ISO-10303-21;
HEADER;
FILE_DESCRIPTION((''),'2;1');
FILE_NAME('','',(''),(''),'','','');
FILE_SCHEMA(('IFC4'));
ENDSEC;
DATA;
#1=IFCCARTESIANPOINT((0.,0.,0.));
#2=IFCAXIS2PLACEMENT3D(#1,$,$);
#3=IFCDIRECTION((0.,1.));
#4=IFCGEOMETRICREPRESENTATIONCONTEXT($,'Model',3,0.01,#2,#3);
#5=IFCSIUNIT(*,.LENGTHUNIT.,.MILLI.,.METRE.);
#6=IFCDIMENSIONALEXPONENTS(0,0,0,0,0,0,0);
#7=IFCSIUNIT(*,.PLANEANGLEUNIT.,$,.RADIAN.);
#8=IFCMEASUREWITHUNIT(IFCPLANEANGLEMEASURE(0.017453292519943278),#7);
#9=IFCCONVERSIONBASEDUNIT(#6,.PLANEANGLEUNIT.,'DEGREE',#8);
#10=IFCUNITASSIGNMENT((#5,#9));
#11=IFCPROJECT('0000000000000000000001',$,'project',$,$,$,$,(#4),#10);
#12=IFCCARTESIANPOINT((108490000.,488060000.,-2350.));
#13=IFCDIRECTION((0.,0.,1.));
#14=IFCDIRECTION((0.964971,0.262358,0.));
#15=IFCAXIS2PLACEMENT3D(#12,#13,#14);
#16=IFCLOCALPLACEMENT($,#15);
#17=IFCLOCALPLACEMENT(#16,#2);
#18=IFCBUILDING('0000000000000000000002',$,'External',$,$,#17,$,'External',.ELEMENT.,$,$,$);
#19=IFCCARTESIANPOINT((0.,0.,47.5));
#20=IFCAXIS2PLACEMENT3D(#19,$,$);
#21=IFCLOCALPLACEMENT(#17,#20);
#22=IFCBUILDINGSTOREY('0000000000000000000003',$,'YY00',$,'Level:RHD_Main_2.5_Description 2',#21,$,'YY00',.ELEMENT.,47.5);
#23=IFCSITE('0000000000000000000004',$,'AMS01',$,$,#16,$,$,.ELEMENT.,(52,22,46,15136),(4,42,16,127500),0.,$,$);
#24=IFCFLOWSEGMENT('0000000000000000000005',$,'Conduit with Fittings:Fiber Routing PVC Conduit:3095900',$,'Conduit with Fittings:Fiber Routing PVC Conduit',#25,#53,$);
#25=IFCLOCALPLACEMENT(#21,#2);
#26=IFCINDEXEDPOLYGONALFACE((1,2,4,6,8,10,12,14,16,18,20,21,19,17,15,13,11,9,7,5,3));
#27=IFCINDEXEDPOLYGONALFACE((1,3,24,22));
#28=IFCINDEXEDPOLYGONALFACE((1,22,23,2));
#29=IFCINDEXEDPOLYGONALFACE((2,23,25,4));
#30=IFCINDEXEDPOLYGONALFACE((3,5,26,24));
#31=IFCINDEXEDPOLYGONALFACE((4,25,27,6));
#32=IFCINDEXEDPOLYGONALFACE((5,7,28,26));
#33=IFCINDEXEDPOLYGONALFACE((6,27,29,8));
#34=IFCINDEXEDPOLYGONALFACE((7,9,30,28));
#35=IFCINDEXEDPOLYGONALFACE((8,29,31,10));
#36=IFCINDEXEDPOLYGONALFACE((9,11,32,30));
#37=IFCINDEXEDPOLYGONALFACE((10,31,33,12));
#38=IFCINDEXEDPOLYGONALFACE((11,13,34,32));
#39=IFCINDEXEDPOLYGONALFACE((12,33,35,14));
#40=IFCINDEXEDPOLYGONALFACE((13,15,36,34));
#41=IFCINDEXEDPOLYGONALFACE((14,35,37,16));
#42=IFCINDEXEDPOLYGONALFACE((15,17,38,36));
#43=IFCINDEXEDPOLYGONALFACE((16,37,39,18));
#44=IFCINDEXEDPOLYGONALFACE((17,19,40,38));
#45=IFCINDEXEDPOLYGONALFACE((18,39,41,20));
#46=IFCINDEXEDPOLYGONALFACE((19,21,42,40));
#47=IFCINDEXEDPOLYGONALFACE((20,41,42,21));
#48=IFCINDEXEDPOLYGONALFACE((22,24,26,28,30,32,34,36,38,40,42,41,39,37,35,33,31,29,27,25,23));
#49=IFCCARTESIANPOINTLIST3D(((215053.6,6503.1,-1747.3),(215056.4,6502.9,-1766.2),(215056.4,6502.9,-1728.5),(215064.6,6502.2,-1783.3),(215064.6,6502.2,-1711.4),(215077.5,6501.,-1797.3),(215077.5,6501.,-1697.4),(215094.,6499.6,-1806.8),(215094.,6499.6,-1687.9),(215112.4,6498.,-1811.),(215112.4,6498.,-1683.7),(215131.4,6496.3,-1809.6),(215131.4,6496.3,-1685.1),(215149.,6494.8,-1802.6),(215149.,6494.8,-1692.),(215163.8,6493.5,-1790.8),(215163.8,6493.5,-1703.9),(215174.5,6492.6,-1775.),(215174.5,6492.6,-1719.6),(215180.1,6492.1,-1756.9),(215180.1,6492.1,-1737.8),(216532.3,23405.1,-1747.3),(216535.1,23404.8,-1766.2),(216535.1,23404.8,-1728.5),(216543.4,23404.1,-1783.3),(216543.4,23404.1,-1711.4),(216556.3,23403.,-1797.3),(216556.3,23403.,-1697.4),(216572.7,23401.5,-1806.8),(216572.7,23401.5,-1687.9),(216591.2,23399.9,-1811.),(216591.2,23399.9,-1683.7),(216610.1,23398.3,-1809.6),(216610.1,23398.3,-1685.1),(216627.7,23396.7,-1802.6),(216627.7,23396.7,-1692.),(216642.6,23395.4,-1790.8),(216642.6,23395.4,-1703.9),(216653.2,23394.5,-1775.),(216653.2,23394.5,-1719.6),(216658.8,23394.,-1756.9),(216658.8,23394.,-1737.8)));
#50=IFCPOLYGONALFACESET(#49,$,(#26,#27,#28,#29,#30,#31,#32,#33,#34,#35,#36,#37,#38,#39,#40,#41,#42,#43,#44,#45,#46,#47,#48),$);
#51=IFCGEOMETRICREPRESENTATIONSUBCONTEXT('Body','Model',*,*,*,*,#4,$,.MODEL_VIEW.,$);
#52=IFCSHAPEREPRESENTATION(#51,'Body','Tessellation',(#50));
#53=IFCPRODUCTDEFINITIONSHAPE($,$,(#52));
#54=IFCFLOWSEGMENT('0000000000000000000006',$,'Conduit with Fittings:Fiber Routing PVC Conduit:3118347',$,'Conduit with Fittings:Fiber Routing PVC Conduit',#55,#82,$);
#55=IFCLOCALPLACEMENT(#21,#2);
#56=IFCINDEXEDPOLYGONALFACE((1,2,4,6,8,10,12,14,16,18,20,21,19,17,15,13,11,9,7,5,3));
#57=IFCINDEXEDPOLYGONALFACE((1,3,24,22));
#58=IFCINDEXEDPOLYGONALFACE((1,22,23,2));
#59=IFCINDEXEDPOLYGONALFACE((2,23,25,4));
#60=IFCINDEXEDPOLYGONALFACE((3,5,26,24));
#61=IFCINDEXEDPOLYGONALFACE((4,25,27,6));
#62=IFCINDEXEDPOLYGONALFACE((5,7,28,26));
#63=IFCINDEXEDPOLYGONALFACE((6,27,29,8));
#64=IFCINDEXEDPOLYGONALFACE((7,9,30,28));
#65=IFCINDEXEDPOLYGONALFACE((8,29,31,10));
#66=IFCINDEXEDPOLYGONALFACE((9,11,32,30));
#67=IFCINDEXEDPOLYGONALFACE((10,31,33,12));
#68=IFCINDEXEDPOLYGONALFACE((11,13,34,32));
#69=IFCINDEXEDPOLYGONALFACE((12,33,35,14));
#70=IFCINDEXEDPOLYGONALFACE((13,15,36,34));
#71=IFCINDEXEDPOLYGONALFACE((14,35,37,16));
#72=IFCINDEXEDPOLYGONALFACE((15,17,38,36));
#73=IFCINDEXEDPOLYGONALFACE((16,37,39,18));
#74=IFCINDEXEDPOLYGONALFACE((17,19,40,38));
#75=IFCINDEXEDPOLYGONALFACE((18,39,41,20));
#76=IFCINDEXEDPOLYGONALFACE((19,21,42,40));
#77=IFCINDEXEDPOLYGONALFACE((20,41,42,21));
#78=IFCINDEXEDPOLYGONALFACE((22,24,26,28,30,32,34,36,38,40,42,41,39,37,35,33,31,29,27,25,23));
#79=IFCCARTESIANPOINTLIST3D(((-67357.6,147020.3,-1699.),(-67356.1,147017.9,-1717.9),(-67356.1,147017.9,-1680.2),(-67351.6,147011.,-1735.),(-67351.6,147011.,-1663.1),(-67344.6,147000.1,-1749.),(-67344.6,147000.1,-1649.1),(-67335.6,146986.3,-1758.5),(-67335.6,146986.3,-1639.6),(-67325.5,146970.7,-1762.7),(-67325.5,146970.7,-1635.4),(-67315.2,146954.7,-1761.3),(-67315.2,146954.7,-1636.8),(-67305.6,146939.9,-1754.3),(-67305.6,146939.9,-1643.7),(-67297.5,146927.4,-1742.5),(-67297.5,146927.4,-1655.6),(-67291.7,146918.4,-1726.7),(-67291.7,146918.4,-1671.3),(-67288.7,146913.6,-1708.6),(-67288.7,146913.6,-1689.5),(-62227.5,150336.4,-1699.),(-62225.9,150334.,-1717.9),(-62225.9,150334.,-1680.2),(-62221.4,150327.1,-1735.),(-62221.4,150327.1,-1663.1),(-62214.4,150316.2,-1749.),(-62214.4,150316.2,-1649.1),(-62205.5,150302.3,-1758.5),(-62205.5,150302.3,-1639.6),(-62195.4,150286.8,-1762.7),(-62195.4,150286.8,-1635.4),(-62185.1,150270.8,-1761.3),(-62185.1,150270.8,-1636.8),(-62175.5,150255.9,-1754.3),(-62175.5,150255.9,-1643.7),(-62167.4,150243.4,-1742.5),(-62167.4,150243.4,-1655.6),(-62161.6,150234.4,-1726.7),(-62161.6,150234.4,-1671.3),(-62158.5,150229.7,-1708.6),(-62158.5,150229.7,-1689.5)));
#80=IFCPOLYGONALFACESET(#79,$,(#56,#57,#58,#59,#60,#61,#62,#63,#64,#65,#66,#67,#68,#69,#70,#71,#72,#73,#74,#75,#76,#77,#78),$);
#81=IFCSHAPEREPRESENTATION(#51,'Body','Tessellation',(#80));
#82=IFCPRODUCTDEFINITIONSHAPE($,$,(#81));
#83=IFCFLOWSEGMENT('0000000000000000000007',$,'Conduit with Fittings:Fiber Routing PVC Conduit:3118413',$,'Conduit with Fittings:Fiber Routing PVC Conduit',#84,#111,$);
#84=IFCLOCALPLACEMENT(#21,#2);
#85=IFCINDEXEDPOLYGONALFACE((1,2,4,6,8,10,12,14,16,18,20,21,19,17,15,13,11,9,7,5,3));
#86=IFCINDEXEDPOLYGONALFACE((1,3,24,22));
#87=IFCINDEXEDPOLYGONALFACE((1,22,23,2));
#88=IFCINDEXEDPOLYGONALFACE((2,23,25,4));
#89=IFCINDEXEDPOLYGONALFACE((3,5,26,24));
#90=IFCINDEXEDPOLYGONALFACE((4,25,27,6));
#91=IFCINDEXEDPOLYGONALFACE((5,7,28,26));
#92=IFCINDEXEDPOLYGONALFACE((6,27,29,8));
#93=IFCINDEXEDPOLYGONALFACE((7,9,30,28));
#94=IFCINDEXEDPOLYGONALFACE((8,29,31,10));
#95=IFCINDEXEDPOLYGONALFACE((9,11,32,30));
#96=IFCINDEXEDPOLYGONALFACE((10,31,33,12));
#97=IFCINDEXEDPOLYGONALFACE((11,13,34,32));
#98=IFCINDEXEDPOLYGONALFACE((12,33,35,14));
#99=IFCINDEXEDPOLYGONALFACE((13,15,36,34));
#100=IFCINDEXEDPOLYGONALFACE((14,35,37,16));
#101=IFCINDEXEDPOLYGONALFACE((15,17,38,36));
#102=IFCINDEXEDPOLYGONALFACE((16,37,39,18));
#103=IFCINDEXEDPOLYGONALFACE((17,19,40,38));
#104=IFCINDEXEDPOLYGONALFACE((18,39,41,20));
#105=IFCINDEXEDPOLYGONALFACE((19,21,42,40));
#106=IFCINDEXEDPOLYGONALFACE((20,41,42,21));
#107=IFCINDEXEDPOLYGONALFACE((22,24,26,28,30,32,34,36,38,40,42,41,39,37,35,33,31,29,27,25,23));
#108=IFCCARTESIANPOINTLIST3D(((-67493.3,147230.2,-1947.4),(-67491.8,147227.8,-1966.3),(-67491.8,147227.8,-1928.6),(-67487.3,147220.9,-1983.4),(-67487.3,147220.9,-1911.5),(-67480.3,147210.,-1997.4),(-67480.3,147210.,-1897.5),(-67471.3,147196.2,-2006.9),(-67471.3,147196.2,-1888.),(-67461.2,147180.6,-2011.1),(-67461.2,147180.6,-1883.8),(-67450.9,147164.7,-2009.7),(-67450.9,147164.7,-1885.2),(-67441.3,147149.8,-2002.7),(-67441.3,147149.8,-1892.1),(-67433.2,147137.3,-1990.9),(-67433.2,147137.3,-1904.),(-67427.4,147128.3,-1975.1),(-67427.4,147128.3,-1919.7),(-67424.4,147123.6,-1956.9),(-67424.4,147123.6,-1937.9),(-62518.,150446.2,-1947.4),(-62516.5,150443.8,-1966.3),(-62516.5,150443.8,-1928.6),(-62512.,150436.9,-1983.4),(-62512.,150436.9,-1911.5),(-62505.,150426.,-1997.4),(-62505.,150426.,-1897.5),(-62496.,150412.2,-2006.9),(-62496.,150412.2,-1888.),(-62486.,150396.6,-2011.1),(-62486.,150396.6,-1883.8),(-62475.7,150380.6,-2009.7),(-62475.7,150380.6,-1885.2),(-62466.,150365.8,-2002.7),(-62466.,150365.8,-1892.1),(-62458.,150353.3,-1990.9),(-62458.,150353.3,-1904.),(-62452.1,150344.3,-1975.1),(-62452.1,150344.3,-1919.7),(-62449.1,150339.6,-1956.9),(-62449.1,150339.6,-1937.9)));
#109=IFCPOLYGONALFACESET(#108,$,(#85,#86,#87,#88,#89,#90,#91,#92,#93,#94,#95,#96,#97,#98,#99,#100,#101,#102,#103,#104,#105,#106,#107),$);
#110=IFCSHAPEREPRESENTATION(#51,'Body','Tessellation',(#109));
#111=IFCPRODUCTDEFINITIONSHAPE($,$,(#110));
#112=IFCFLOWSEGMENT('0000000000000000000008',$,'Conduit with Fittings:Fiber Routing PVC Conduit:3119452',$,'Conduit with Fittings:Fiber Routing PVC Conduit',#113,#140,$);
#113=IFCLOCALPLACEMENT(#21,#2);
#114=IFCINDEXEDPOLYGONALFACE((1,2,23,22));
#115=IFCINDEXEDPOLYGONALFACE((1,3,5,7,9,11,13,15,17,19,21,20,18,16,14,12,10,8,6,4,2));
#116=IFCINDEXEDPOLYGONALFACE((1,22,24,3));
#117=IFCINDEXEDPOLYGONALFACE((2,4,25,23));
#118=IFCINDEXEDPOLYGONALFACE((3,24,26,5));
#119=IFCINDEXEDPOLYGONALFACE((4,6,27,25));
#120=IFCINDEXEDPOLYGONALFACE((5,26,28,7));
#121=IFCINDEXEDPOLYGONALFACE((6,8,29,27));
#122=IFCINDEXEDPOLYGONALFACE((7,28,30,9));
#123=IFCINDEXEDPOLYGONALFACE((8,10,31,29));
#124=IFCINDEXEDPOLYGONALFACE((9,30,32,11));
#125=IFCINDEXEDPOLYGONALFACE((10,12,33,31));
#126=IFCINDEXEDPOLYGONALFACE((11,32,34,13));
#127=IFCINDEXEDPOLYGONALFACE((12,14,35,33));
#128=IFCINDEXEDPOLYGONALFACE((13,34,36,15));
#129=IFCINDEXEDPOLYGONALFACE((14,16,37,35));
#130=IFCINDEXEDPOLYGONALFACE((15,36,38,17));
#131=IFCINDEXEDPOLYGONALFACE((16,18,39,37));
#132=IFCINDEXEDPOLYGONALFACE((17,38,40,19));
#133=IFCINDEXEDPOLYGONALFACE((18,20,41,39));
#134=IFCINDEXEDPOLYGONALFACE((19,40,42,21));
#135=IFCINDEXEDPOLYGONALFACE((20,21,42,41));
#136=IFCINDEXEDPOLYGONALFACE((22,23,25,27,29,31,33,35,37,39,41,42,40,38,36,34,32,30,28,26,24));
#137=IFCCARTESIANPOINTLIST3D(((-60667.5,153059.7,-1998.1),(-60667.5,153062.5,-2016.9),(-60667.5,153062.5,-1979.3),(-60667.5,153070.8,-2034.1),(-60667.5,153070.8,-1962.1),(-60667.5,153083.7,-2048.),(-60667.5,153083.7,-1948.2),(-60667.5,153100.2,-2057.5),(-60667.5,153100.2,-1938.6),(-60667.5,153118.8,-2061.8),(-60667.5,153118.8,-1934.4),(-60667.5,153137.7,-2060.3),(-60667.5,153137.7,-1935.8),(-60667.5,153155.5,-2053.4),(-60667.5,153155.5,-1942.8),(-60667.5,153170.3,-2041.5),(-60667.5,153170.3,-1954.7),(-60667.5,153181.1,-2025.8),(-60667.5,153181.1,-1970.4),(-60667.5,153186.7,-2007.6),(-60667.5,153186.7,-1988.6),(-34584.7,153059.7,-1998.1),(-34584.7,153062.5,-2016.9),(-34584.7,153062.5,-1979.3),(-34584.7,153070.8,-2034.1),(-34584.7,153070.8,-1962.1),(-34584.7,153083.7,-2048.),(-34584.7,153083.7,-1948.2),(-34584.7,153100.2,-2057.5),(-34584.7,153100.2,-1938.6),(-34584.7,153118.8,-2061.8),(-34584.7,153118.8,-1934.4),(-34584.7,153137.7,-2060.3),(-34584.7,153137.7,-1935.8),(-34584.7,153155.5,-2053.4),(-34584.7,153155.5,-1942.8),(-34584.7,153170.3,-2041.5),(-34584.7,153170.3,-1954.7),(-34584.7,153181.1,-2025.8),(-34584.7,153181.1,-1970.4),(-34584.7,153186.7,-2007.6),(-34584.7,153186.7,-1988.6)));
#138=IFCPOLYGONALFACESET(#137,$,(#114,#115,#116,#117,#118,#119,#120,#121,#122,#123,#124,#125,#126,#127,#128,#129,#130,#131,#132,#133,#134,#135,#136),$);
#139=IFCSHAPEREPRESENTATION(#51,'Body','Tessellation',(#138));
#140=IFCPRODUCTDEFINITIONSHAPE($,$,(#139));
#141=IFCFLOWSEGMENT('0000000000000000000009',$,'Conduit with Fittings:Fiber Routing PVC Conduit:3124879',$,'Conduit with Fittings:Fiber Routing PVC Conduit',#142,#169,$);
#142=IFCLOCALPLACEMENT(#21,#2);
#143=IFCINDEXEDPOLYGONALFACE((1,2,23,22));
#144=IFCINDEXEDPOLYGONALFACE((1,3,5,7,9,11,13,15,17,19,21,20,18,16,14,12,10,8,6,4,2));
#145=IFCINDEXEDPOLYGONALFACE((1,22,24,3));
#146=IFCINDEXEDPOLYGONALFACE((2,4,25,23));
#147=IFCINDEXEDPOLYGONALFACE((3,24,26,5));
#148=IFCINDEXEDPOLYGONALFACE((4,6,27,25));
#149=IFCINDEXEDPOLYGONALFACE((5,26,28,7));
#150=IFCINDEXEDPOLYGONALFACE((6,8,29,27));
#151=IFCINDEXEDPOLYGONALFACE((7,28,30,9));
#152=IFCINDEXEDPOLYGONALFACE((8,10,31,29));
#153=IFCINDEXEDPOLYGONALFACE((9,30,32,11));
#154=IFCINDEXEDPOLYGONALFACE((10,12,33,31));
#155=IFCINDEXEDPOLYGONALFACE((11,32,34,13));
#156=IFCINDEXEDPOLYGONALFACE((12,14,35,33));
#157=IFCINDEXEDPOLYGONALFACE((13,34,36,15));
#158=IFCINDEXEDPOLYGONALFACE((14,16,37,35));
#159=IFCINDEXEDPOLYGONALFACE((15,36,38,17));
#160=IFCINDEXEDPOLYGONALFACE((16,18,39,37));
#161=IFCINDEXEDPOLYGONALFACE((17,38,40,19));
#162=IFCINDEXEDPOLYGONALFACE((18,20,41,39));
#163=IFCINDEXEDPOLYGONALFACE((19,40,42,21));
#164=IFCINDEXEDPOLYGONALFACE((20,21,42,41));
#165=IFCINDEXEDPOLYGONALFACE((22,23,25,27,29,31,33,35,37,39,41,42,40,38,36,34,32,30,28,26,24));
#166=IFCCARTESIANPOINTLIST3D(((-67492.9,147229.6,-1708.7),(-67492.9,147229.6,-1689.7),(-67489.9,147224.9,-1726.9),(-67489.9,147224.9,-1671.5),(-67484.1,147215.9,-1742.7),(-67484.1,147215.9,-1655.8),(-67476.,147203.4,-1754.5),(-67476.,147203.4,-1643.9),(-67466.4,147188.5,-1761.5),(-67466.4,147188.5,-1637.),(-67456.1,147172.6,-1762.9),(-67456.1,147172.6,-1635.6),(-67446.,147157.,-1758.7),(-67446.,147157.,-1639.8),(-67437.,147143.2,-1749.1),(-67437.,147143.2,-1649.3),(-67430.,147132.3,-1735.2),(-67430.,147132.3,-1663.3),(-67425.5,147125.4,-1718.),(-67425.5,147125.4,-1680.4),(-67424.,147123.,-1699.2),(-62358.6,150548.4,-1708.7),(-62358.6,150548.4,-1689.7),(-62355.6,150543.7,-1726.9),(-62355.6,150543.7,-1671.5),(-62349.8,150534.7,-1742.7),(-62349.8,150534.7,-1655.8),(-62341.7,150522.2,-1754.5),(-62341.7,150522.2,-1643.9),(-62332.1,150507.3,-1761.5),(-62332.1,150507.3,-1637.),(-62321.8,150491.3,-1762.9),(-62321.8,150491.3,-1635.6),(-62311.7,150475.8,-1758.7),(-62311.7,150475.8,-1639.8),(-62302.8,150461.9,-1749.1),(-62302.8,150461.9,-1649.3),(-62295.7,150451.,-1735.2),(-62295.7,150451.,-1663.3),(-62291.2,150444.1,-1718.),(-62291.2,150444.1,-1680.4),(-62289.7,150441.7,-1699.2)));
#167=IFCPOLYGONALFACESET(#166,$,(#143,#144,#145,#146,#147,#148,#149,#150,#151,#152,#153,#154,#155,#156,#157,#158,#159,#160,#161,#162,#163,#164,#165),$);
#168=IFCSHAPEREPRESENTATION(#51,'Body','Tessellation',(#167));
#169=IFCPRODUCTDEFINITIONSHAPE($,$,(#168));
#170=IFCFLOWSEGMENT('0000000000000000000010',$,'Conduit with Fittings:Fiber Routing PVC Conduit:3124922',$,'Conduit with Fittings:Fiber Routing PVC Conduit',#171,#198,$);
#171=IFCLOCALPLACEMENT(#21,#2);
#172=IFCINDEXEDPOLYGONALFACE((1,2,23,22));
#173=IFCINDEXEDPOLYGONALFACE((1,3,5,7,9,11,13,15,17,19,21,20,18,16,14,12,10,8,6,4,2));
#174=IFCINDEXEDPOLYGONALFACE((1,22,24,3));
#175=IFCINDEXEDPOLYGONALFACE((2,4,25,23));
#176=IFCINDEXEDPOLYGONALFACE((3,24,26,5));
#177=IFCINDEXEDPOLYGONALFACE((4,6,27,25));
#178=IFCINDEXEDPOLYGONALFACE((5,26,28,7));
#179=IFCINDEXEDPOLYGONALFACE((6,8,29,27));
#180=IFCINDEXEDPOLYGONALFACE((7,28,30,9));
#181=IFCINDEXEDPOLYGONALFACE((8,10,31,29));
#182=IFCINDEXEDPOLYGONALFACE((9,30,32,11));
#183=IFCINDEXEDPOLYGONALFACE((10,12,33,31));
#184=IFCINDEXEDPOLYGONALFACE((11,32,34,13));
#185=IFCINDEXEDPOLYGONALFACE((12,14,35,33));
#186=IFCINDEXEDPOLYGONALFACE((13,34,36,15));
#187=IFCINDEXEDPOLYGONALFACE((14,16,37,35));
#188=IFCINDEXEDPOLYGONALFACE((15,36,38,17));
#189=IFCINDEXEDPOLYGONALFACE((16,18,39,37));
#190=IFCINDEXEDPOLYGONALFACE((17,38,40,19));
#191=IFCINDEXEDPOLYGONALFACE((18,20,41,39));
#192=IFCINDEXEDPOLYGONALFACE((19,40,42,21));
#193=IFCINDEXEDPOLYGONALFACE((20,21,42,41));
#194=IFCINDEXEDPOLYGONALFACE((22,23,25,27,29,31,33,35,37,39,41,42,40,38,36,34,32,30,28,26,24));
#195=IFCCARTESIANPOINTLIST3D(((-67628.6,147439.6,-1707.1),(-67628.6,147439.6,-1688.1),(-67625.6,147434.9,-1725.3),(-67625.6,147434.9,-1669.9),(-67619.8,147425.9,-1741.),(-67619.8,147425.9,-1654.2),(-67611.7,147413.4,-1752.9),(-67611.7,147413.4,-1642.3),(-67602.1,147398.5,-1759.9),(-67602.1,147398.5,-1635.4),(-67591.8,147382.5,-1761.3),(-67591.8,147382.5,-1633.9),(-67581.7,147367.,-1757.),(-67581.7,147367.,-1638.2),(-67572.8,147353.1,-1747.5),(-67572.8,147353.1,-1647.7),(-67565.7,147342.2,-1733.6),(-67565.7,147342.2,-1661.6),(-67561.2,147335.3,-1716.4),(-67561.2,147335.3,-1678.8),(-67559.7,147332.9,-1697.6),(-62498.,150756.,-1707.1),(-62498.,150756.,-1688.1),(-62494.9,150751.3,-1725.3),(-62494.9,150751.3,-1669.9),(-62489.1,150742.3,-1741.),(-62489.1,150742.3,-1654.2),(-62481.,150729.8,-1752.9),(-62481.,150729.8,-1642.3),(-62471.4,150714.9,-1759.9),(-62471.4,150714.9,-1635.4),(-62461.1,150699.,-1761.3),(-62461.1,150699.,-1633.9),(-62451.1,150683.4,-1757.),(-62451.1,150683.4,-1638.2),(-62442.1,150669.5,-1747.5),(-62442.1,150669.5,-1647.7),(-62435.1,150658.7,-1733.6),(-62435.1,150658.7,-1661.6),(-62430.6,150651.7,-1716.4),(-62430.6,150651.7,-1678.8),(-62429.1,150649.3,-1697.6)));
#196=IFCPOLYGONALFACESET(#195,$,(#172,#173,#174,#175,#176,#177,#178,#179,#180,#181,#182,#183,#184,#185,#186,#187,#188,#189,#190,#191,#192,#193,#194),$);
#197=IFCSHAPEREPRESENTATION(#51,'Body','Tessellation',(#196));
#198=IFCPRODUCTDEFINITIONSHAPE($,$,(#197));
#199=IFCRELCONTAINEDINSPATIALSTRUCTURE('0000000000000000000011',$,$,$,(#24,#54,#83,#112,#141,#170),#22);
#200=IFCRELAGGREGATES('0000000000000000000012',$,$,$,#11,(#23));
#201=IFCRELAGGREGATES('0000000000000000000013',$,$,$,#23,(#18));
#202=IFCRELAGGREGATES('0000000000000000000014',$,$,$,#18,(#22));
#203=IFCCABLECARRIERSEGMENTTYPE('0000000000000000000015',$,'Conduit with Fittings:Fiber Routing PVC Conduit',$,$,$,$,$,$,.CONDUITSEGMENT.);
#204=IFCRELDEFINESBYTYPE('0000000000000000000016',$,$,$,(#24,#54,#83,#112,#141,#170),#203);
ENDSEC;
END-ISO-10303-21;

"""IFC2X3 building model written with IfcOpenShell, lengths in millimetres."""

from ifc_helpers import new_model, entity, si_unit, converted_unit, direction, frame, frame_2d, origin, origin_2d_with_axis, place, context, subcontext, project, spatial, circle, extrude, type_object, element, save


model = new_model("IFC2X3")

# Units and contexts
model_context = context("Model", 3, precision=0.01, world=origin(), true_north=direction((0.0, 1.0)))
body_context = subcontext(model_context, "Body", "Model", "MODEL_VIEW")
ifc_project = project(units=[si_unit("LENGTHUNIT", "METRE", prefix="MILLI"), converted_unit("PLANEANGLEUNIT", "DEGREE", entity("IfcPlaneAngleMeasure", 0.017453292519943278), si_unit("PLANEANGLEUNIT", "RADIAN"), dimensions=[0, 0, 0, 0, 0, 0, 0])], contexts=[model_context])

# Site, building, storey
site_placement = place(None, frame((108490000.0, 488060000.0, -2350.0), z_axis=(0.0, 0.0, 1.0), x_axis=(0.964971, 0.262358, 0.0)))
site = spatial("IfcSite", under=ifc_project, at=site_placement, Name="AMS01", CompositionType="ELEMENT", RefLatitude=(52, 22, 46, 15136), RefLongitude=(4, 42, 16, 127500), RefElevation=0.0)
building_placement = place(site_placement, origin())
building = spatial("IfcBuilding", under=site, at=building_placement, Name="External", LongName="External", CompositionType="ELEMENT")
storey_placement = place(building_placement, frame((0.0, 0.0, 47.5)))
storey = spatial("IfcBuildingStorey", under=building, at=storey_placement, Name="YY00", ObjectType="Level:RHD_Main_2.5_Description 2", LongName="YY00", CompositionType="ELEMENT", Elevation=47.5)

# Flow segments
cable_carrier_segment_type = type_object("IfcCableCarrierSegmentType", Name="Conduit with Fittings:Fiber Routing PVC Conduit", PredefinedType="CONDUITSEGMENT")
flow_segment_1_placement = place(storey_placement, origin())
element("IfcFlowSegment", 1, at=flow_segment_1_placement, inside=storey, type_object=cable_carrier_segment_type, Name="Conduit with Fittings:Fiber Routing PVC Conduit:3095900", ObjectType="Conduit with Fittings:Fiber Routing PVC Conduit", context=body_context, shape_type="SweptSolid", body=[
    extrude(circle(Radius=63.9, at=frame_2d((0.0, 0.0), x_axis=(1.0, 0.0))), frame((215117.2, 6497.6, -1747.3), z_axis=(0.087156, 0.996195, 0.0), x_axis=(-0.996195, 0.087156, 0.0)), (0.0, 0.0, 1.0), 16966.5),
])
flow_segment_2_placement = place(storey_placement, origin())
element("IfcFlowSegment", 2, at=flow_segment_2_placement, inside=storey, type_object=cable_carrier_segment_type, Name="Conduit with Fittings:Fiber Routing PVC Conduit:3118347", ObjectType="Conduit with Fittings:Fiber Routing PVC Conduit", context=body_context, shape_type="SweptSolid", body=[
    extrude(circle(Radius=63.9, at=frame_2d((0.0, 0.0), x_axis=(1.0, 0.0))), frame((-67323.0, 146966.7, -1699.0), z_axis=(0.839826, 0.542856, 0.0), x_axis=(-0.542856, 0.839826, 0.0)), (0.0, 0.0, 1.0), 6108.6),
])
flow_segment_3_placement = place(storey_placement, origin())
element("IfcFlowSegment", 3, at=flow_segment_3_placement, inside=storey, type_object=cable_carrier_segment_type, Name="Conduit with Fittings:Fiber Routing PVC Conduit:3118413", ObjectType="Conduit with Fittings:Fiber Routing PVC Conduit", context=body_context, shape_type="SweptSolid", body=[
    extrude(circle(Radius=63.9, at=frame_2d((0.0, 0.0), x_axis=(1.0, 0.0))), frame((-67458.6, 147176.6, -1947.4), z_axis=(0.839826, 0.542856, 0.0), x_axis=(-0.542856, 0.839826, 0.0)), (0.0, 0.0, 1.0), 5924.2),
])
flow_segment_4_placement = place(storey_placement, origin())
element("IfcFlowSegment", 4, at=flow_segment_4_placement, inside=storey, type_object=cable_carrier_segment_type, Name="Conduit with Fittings:Fiber Routing PVC Conduit:3119452", ObjectType="Conduit with Fittings:Fiber Routing PVC Conduit", context=body_context, shape_type="SweptSolid", body=[
    extrude(circle(Radius=63.9, at=origin_2d_with_axis()), frame((-60667.5, 153123.5, -1998.1), z_axis=(1.0, 0.0, 0.0), x_axis=(0.0, -1.0, 0.0)), (0.0, 0.0, 1.0), 26082.9),
])
flow_segment_5_placement = place(storey_placement, origin())
element("IfcFlowSegment", 5, at=flow_segment_5_placement, inside=storey, type_object=cable_carrier_segment_type, Name="Conduit with Fittings:Fiber Routing PVC Conduit:3124879", ObjectType="Conduit with Fittings:Fiber Routing PVC Conduit", context=body_context, shape_type="SweptSolid", body=[
    extrude(circle(Radius=63.9, at=frame_2d((0.0, 0.0), x_axis=(1.0, 0.0))), frame((-67458.6, 147176.6, -1699.2), z_axis=(0.839826, 0.542856, 0.0), x_axis=(0.542856, -0.839826, 0.0)), (0.0, 0.0, 1.0), 6113.5),
])
flow_segment_6_placement = place(storey_placement, origin())
element("IfcFlowSegment", 6, at=flow_segment_6_placement, inside=storey, type_object=cable_carrier_segment_type, Name="Conduit with Fittings:Fiber Routing PVC Conduit:3124922", ObjectType="Conduit with Fittings:Fiber Routing PVC Conduit", context=body_context, shape_type="SweptSolid", body=[
    extrude(circle(Radius=63.9, at=origin_2d_with_axis()), frame((-67594.4, 147386.6, -1697.6), z_axis=(0.839826, 0.542856, 0.0), x_axis=(0.542856, -0.839826, 0.0)), (0.0, 0.0, 1.0), 6109.2),
])

save(model, "model.ifc")
